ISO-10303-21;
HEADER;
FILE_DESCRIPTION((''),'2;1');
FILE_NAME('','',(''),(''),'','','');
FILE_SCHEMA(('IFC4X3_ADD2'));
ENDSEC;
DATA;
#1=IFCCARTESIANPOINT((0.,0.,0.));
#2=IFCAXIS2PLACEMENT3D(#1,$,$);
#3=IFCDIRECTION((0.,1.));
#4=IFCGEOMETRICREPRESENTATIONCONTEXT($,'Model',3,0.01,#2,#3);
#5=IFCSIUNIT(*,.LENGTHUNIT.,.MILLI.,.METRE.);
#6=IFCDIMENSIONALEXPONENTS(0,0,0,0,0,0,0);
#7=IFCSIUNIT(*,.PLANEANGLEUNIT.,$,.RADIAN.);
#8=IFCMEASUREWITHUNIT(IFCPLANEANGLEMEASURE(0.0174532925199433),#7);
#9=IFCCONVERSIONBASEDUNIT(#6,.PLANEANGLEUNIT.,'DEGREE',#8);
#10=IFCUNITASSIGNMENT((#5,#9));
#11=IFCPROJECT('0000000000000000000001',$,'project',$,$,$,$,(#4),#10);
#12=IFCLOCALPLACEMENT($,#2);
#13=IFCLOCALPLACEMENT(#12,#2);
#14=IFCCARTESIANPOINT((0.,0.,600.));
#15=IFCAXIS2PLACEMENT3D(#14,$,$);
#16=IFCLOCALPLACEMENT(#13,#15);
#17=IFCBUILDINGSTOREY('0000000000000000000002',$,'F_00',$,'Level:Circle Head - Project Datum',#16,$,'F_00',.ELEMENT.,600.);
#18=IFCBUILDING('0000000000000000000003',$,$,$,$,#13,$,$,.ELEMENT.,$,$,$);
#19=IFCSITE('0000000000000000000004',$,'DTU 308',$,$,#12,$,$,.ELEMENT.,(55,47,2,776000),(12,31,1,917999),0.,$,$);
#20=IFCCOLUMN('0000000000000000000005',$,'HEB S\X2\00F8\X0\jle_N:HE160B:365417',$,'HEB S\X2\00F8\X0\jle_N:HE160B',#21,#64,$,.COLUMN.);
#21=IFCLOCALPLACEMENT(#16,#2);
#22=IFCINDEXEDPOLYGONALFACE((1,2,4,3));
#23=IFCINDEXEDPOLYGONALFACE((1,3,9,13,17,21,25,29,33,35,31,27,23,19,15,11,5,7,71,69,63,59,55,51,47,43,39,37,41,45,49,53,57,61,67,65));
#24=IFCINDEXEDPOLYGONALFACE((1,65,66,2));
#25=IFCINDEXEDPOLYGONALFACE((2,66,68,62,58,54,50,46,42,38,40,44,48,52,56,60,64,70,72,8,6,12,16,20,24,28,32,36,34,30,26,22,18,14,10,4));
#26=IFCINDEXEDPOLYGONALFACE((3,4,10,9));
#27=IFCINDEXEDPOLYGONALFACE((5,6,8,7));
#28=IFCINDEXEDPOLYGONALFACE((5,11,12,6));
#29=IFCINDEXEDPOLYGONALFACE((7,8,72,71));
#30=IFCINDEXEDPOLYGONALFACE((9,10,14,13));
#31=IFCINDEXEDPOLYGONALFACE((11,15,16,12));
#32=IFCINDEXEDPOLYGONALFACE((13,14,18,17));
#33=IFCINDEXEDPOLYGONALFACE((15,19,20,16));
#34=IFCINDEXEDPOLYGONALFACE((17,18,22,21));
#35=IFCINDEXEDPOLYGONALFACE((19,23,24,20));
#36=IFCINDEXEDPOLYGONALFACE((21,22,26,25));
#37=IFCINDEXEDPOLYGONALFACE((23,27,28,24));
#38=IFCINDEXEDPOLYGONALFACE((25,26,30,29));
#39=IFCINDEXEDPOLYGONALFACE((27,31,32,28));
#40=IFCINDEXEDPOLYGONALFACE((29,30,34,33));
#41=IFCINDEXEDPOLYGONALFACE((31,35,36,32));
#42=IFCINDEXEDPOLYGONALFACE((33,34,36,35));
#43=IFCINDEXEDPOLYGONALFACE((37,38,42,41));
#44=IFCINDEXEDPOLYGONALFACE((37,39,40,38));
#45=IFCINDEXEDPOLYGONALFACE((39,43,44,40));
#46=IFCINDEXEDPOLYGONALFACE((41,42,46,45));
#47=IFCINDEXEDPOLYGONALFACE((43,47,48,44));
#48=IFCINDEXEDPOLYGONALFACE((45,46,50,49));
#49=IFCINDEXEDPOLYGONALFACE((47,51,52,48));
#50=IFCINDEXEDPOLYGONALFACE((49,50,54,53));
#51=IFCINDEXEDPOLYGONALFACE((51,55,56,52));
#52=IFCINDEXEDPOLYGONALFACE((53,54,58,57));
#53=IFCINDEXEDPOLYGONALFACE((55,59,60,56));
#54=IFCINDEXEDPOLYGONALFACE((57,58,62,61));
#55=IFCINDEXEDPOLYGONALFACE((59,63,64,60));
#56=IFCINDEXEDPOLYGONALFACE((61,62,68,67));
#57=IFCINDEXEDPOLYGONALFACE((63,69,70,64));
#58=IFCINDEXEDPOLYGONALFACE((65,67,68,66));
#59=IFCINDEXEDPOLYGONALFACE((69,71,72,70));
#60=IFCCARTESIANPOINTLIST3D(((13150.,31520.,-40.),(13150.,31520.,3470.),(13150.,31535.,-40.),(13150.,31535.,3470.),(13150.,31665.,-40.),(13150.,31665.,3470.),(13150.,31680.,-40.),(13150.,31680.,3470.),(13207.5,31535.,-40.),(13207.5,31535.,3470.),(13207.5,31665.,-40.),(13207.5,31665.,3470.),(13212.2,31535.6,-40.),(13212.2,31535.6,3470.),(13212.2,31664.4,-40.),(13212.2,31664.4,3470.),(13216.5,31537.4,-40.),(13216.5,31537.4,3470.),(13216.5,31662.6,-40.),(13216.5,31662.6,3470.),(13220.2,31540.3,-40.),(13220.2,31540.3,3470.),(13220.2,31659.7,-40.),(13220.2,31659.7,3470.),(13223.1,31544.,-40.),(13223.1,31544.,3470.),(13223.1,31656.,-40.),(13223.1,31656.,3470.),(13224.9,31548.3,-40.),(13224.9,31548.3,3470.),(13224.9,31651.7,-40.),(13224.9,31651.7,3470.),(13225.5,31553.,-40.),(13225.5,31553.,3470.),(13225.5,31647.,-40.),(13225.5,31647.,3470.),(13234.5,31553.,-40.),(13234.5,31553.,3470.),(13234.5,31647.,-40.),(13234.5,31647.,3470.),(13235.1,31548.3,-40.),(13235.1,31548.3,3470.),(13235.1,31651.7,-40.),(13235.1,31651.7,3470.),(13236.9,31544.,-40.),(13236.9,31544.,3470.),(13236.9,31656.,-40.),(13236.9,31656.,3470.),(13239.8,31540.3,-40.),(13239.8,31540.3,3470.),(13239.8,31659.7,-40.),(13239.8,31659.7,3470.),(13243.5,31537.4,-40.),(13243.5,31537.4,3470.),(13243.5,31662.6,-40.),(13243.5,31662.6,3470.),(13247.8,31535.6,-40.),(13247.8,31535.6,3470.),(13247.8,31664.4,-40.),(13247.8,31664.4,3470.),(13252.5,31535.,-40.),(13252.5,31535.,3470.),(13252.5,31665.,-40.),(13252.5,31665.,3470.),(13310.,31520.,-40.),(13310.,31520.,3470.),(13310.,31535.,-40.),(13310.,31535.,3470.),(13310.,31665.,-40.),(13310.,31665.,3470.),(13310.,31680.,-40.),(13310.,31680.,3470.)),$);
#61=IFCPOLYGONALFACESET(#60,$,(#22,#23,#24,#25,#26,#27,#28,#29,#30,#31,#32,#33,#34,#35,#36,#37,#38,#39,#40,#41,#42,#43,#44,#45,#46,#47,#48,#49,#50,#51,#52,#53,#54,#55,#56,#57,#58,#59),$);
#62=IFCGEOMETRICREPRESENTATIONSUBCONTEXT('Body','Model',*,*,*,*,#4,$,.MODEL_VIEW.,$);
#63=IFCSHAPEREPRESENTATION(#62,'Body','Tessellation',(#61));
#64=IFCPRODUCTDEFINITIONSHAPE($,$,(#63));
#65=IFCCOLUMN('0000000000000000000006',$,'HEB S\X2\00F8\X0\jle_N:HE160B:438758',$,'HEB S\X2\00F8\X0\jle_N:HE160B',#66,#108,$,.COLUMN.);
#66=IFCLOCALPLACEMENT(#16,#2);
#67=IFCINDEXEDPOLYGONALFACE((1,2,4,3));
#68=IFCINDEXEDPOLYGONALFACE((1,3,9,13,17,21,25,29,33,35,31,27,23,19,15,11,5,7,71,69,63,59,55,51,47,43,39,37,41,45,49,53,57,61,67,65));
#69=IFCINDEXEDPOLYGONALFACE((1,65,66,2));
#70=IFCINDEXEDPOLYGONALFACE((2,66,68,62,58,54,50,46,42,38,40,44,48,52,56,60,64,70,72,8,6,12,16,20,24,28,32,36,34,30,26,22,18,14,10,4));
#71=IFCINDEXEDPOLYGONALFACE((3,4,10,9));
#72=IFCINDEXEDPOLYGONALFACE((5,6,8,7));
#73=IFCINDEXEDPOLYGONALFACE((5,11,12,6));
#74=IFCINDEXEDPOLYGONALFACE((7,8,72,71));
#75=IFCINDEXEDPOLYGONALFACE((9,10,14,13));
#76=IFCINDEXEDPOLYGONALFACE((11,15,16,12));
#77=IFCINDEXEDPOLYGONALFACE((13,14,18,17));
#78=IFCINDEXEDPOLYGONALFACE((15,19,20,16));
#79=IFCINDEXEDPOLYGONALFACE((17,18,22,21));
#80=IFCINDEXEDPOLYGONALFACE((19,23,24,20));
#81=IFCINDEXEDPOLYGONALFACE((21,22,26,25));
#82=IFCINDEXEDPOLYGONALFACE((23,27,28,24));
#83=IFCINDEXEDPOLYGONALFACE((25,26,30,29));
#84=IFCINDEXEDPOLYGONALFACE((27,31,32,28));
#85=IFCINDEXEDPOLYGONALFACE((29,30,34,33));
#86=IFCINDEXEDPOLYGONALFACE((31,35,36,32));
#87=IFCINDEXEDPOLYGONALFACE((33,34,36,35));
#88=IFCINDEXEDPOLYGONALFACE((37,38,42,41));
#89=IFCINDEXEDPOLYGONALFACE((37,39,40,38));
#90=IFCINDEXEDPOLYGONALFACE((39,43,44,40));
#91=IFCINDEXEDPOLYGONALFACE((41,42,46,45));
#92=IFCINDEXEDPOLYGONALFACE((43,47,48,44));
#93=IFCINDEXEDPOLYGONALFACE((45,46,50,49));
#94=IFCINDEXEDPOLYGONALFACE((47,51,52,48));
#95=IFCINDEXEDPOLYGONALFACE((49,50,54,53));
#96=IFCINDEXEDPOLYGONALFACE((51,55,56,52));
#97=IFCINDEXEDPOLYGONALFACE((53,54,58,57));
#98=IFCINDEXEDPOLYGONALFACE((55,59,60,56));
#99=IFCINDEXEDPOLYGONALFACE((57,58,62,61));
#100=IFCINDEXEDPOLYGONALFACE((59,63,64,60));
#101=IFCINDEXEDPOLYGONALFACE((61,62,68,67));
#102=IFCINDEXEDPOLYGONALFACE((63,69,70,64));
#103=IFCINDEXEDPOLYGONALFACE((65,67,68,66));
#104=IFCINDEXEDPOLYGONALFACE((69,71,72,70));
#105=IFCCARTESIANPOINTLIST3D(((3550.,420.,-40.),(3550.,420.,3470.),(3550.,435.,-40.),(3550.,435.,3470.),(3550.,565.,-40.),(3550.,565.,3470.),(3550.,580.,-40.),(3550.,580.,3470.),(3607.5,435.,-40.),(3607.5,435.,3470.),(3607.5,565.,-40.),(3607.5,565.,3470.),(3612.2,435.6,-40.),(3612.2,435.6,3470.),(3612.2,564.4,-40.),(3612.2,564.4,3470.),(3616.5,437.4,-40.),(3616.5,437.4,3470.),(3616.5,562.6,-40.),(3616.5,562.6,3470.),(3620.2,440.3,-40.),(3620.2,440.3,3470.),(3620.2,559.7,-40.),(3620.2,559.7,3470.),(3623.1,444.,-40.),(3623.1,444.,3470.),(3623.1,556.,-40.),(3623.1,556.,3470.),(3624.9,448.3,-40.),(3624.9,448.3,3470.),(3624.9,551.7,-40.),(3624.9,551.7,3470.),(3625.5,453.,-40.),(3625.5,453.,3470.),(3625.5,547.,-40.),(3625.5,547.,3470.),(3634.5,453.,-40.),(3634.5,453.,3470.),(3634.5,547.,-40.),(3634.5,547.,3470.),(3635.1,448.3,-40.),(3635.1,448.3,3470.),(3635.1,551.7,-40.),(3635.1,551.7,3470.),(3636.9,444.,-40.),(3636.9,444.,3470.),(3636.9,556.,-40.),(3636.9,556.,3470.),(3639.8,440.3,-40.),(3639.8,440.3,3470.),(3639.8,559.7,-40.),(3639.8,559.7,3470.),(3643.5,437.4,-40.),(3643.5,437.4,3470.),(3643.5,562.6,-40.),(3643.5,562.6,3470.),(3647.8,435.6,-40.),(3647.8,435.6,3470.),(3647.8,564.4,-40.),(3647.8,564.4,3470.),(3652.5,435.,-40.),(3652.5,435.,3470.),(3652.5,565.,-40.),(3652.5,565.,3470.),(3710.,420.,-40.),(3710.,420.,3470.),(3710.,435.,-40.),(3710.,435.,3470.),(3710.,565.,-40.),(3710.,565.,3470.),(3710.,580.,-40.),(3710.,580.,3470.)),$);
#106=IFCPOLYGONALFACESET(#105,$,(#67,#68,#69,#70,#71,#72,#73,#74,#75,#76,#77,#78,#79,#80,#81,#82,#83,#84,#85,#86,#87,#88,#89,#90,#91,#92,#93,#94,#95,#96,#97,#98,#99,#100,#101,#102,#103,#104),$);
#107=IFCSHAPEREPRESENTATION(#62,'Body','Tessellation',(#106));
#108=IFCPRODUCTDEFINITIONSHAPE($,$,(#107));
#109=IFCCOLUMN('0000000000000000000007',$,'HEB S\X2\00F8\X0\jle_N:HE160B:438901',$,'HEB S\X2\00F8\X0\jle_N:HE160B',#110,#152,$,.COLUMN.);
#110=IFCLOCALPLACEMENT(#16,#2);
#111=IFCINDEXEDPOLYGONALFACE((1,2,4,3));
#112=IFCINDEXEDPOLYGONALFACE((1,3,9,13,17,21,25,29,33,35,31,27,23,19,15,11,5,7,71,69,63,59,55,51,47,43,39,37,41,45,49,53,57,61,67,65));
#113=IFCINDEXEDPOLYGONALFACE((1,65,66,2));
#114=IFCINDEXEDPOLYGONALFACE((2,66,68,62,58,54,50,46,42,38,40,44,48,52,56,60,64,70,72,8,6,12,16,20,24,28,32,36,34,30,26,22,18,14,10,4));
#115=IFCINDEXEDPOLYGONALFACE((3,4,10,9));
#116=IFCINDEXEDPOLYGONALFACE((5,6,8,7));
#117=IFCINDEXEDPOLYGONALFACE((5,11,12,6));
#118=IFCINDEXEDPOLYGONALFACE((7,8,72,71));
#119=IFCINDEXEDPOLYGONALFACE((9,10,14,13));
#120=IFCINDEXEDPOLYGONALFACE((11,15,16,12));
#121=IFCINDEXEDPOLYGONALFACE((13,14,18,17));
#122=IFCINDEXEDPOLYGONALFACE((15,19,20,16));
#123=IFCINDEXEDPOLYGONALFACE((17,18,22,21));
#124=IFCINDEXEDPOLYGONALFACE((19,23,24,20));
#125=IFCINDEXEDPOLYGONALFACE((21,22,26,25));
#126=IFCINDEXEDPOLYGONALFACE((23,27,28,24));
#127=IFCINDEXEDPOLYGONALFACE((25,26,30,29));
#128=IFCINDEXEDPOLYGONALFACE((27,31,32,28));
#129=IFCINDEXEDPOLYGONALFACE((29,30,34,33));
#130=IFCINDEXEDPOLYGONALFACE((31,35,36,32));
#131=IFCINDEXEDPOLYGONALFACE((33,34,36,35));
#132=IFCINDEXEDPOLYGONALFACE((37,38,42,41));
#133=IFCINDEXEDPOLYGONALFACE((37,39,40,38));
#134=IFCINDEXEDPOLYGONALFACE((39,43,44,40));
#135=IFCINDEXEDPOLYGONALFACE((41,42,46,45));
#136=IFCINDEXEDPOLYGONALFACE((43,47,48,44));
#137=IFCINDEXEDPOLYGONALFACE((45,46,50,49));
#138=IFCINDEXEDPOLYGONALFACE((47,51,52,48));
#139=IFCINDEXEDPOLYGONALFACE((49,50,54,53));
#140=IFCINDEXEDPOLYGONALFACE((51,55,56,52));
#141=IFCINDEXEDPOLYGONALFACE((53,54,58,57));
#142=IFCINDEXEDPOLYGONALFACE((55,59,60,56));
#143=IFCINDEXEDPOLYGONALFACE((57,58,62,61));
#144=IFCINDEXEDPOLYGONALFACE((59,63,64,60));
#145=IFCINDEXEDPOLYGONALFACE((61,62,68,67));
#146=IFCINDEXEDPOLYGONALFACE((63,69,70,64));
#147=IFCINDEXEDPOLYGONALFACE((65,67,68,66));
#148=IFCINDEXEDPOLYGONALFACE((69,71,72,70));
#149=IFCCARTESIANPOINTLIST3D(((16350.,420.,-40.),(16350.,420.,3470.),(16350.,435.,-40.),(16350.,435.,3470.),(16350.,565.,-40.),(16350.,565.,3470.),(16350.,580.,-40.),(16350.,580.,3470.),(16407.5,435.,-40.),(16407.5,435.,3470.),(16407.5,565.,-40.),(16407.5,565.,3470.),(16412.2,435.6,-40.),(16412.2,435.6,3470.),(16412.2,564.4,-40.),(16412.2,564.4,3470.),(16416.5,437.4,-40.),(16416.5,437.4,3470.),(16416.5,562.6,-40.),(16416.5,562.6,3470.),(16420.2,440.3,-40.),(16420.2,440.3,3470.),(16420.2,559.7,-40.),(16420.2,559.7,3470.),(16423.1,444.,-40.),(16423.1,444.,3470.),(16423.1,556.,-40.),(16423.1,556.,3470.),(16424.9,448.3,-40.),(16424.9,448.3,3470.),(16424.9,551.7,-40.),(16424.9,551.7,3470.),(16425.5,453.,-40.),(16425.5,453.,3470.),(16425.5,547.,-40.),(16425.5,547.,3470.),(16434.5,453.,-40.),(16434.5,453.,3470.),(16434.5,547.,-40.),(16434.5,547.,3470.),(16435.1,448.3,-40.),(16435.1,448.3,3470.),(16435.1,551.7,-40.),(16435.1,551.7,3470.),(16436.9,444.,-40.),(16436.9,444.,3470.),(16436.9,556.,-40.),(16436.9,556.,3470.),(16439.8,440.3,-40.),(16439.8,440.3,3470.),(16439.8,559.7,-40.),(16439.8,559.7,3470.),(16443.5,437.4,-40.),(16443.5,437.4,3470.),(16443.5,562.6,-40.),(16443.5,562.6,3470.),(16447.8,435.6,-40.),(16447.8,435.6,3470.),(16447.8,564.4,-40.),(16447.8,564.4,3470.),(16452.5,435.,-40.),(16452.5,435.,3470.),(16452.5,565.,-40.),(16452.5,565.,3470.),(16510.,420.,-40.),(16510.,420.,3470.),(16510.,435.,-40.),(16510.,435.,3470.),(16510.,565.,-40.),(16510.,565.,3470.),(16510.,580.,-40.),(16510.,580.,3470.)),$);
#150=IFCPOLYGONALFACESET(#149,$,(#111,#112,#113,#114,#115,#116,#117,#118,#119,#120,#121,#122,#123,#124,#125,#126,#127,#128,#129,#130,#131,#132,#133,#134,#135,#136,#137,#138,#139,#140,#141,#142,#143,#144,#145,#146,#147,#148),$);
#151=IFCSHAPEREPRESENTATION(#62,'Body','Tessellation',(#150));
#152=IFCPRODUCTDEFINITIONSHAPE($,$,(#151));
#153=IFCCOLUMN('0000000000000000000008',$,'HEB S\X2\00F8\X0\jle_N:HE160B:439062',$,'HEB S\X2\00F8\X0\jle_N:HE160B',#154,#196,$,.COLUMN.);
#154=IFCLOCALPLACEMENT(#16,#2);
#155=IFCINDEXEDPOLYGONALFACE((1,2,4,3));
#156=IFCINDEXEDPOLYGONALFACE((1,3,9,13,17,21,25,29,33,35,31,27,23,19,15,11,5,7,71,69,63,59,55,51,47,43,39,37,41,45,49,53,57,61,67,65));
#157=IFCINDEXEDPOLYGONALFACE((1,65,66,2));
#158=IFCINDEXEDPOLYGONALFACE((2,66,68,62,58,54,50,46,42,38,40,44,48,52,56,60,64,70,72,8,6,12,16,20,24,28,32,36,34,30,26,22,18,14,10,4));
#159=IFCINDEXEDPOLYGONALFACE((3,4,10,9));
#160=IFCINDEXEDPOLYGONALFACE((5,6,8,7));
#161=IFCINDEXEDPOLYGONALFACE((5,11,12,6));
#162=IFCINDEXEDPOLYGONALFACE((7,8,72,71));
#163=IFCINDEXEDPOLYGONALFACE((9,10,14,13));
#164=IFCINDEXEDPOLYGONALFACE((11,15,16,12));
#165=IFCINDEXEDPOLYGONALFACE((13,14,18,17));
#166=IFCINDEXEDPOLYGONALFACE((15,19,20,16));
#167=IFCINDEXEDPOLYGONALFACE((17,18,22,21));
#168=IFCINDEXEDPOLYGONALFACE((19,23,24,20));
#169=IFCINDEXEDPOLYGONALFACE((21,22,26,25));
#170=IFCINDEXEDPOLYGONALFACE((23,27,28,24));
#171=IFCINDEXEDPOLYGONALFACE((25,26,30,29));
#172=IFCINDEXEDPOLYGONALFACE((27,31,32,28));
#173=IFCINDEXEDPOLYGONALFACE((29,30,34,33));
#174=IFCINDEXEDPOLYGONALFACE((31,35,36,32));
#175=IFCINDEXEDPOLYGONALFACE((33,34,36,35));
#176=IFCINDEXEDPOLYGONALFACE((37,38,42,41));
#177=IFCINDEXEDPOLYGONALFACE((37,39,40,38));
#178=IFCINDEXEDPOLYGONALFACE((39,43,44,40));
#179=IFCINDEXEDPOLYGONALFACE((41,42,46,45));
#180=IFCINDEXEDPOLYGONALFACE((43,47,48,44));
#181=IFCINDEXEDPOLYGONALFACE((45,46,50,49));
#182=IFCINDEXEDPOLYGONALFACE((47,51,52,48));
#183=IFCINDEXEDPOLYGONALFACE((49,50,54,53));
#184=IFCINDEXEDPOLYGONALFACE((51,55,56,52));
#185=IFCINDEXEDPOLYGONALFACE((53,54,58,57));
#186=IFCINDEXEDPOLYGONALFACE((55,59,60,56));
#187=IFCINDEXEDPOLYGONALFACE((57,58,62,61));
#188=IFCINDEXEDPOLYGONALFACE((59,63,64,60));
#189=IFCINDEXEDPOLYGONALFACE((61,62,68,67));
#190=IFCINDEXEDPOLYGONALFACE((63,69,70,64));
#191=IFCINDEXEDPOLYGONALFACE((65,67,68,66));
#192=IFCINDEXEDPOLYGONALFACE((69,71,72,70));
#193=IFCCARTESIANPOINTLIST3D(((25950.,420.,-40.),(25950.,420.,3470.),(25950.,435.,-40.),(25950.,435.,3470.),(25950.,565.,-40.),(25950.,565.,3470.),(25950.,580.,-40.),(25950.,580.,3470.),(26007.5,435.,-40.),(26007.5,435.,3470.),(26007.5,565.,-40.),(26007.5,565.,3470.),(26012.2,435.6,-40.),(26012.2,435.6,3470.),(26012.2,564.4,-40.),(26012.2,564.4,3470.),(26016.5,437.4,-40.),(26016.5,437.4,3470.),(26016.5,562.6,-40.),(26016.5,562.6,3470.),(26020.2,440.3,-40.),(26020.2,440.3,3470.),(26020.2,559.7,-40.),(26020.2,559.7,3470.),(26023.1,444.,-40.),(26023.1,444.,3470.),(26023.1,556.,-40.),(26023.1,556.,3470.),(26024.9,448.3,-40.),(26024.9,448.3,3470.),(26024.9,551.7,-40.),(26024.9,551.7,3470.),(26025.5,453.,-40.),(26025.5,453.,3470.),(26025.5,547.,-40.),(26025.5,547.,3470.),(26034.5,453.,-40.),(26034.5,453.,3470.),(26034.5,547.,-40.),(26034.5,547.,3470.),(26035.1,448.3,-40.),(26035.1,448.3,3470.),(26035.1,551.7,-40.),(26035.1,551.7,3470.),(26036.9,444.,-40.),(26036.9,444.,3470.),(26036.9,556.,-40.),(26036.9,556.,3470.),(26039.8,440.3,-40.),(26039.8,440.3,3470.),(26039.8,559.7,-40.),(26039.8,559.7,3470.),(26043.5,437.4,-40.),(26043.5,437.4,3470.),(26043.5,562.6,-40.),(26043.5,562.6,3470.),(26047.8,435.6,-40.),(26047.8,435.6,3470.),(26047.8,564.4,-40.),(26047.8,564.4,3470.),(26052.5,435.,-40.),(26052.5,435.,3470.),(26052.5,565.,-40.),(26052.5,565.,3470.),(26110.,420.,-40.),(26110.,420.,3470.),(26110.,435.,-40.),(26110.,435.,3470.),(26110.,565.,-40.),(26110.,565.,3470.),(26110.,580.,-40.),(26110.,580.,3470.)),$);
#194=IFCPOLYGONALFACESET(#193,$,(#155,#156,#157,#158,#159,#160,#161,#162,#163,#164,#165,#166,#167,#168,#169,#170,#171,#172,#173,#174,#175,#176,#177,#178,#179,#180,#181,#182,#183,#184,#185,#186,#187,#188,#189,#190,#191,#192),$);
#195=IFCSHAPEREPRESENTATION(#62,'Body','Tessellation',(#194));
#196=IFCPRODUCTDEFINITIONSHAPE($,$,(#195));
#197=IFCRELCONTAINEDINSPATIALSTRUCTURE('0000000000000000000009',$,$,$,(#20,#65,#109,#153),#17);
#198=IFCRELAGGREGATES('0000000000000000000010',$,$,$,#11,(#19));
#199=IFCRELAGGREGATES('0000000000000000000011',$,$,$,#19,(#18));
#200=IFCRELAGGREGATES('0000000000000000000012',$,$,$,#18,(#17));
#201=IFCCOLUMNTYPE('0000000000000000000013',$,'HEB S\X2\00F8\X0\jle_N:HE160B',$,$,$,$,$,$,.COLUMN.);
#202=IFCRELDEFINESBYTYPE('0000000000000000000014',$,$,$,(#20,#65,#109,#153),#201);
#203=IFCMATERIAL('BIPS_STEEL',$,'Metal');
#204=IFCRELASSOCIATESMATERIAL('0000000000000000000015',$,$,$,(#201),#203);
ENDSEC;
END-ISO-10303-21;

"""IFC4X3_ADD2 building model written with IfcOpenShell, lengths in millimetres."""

from ifc_helpers import new_model, entity, si_unit, converted_unit, direction, frame, frame_2d, origin, place, context, subcontext, project, spatial, i_section, extrude, source, transform, mapped, material, material_profile, profile_set, type_object, type_shapes, element, save


model = new_model("IFC4X3_ADD2")

# Units and contexts
model_context = context("Model", 3, precision=0.01, world=origin(), true_north=direction((0.0, 1.0)))
body_context = subcontext(model_context, "Body", "Model", "MODEL_VIEW")
ifc_project = project(units=[si_unit("LENGTHUNIT", "METRE", prefix="MILLI"), converted_unit("PLANEANGLEUNIT", "DEGREE", entity("IfcPlaneAngleMeasure", 0.0174532925199433), si_unit("PLANEANGLEUNIT", "RADIAN"), dimensions=[0, 0, 0, 0, 0, 0, 0])], contexts=[model_context])

# Site, building, storey
site_placement = place(None, origin())
site = spatial("IfcSite", under=ifc_project, at=site_placement, Name="DTU 308", CompositionType="ELEMENT", RefLatitude=(55, 47, 2, 776000), RefLongitude=(12, 31, 1, 917999), RefElevation=0.0)
building_placement = place(site_placement, origin())
building = spatial("IfcBuilding", under=site, at=building_placement, CompositionType="ELEMENT")
storey_placement = place(building_placement, frame((0.0, 0.0, 600.0)))
storey = spatial("IfcBuildingStorey", under=building, at=storey_placement, Name="F_00", ObjectType="Level:Circle Head - Project Datum", LongName="F_00", CompositionType="ELEMENT", Elevation=600.0)

# Columns
ifc_material_1 = material(Name="BIPS_STEEL", Category="Metal")
ifc_material_profile_1 = material_profile(ifc_material_1, i_section(OverallWidth=160.0, OverallDepth=160.0, WebThickness=9.0, FlangeThickness=15.0, FilletRadius=18.0, at=frame_2d((0.0, 0.0), x_axis=(1.0, 0.0))), Name="HE160B")
ifc_profile_set_1 = profile_set([ifc_material_profile_1], Name="HE160B")
column_type = type_object("IfcColumnType", Name="HEB Søjle_N:HE160B", PredefinedType="COLUMN", material=ifc_profile_set_1)
shared_shape_1 = source(origin(), body_context, "Body", "SweptSolid", [
    extrude(i_section(OverallWidth=160.0, OverallDepth=160.0, WebThickness=9.0, FlangeThickness=15.0, FilletRadius=18.0, at=frame_2d((0.0, 0.0), x_axis=(1.0, 0.0))), frame((0.0, 0.0, 560.0), z_axis=(0.0, 0.0, 1.0), x_axis=(-1.0, 0.0, 0.0)), (0.0, 0.0, 1.0), 3510.0),
])
type_shapes(column_type, [shared_shape_1])
for number, where, name in (
    (1, (13230.0, 31600.0, -600.0), "HEB Søjle_N:HE160B:365417"),
    (2, (3630.0, 500.0, -600.0), "HEB Søjle_N:HE160B:438758"),
    (3, (16430.0, 500.0, -600.0), "HEB Søjle_N:HE160B:438901"),
    (4, (26030.0, 500.0, -600.0), "HEB Søjle_N:HE160B:439062"),
):
    element("IfcColumn", number, at=place(storey_placement, frame(where)), inside=storey, type_object=column_type, Name=name, ObjectType="HEB Søjle_N:HE160B", PredefinedType="COLUMN", context=body_context, shape_type="MappedRepresentation", body=[
        mapped(shared_shape_1, transform((0.0, 0.0, 0.0), scale=1.0)),
    ])

save(model, "model.ifc")
